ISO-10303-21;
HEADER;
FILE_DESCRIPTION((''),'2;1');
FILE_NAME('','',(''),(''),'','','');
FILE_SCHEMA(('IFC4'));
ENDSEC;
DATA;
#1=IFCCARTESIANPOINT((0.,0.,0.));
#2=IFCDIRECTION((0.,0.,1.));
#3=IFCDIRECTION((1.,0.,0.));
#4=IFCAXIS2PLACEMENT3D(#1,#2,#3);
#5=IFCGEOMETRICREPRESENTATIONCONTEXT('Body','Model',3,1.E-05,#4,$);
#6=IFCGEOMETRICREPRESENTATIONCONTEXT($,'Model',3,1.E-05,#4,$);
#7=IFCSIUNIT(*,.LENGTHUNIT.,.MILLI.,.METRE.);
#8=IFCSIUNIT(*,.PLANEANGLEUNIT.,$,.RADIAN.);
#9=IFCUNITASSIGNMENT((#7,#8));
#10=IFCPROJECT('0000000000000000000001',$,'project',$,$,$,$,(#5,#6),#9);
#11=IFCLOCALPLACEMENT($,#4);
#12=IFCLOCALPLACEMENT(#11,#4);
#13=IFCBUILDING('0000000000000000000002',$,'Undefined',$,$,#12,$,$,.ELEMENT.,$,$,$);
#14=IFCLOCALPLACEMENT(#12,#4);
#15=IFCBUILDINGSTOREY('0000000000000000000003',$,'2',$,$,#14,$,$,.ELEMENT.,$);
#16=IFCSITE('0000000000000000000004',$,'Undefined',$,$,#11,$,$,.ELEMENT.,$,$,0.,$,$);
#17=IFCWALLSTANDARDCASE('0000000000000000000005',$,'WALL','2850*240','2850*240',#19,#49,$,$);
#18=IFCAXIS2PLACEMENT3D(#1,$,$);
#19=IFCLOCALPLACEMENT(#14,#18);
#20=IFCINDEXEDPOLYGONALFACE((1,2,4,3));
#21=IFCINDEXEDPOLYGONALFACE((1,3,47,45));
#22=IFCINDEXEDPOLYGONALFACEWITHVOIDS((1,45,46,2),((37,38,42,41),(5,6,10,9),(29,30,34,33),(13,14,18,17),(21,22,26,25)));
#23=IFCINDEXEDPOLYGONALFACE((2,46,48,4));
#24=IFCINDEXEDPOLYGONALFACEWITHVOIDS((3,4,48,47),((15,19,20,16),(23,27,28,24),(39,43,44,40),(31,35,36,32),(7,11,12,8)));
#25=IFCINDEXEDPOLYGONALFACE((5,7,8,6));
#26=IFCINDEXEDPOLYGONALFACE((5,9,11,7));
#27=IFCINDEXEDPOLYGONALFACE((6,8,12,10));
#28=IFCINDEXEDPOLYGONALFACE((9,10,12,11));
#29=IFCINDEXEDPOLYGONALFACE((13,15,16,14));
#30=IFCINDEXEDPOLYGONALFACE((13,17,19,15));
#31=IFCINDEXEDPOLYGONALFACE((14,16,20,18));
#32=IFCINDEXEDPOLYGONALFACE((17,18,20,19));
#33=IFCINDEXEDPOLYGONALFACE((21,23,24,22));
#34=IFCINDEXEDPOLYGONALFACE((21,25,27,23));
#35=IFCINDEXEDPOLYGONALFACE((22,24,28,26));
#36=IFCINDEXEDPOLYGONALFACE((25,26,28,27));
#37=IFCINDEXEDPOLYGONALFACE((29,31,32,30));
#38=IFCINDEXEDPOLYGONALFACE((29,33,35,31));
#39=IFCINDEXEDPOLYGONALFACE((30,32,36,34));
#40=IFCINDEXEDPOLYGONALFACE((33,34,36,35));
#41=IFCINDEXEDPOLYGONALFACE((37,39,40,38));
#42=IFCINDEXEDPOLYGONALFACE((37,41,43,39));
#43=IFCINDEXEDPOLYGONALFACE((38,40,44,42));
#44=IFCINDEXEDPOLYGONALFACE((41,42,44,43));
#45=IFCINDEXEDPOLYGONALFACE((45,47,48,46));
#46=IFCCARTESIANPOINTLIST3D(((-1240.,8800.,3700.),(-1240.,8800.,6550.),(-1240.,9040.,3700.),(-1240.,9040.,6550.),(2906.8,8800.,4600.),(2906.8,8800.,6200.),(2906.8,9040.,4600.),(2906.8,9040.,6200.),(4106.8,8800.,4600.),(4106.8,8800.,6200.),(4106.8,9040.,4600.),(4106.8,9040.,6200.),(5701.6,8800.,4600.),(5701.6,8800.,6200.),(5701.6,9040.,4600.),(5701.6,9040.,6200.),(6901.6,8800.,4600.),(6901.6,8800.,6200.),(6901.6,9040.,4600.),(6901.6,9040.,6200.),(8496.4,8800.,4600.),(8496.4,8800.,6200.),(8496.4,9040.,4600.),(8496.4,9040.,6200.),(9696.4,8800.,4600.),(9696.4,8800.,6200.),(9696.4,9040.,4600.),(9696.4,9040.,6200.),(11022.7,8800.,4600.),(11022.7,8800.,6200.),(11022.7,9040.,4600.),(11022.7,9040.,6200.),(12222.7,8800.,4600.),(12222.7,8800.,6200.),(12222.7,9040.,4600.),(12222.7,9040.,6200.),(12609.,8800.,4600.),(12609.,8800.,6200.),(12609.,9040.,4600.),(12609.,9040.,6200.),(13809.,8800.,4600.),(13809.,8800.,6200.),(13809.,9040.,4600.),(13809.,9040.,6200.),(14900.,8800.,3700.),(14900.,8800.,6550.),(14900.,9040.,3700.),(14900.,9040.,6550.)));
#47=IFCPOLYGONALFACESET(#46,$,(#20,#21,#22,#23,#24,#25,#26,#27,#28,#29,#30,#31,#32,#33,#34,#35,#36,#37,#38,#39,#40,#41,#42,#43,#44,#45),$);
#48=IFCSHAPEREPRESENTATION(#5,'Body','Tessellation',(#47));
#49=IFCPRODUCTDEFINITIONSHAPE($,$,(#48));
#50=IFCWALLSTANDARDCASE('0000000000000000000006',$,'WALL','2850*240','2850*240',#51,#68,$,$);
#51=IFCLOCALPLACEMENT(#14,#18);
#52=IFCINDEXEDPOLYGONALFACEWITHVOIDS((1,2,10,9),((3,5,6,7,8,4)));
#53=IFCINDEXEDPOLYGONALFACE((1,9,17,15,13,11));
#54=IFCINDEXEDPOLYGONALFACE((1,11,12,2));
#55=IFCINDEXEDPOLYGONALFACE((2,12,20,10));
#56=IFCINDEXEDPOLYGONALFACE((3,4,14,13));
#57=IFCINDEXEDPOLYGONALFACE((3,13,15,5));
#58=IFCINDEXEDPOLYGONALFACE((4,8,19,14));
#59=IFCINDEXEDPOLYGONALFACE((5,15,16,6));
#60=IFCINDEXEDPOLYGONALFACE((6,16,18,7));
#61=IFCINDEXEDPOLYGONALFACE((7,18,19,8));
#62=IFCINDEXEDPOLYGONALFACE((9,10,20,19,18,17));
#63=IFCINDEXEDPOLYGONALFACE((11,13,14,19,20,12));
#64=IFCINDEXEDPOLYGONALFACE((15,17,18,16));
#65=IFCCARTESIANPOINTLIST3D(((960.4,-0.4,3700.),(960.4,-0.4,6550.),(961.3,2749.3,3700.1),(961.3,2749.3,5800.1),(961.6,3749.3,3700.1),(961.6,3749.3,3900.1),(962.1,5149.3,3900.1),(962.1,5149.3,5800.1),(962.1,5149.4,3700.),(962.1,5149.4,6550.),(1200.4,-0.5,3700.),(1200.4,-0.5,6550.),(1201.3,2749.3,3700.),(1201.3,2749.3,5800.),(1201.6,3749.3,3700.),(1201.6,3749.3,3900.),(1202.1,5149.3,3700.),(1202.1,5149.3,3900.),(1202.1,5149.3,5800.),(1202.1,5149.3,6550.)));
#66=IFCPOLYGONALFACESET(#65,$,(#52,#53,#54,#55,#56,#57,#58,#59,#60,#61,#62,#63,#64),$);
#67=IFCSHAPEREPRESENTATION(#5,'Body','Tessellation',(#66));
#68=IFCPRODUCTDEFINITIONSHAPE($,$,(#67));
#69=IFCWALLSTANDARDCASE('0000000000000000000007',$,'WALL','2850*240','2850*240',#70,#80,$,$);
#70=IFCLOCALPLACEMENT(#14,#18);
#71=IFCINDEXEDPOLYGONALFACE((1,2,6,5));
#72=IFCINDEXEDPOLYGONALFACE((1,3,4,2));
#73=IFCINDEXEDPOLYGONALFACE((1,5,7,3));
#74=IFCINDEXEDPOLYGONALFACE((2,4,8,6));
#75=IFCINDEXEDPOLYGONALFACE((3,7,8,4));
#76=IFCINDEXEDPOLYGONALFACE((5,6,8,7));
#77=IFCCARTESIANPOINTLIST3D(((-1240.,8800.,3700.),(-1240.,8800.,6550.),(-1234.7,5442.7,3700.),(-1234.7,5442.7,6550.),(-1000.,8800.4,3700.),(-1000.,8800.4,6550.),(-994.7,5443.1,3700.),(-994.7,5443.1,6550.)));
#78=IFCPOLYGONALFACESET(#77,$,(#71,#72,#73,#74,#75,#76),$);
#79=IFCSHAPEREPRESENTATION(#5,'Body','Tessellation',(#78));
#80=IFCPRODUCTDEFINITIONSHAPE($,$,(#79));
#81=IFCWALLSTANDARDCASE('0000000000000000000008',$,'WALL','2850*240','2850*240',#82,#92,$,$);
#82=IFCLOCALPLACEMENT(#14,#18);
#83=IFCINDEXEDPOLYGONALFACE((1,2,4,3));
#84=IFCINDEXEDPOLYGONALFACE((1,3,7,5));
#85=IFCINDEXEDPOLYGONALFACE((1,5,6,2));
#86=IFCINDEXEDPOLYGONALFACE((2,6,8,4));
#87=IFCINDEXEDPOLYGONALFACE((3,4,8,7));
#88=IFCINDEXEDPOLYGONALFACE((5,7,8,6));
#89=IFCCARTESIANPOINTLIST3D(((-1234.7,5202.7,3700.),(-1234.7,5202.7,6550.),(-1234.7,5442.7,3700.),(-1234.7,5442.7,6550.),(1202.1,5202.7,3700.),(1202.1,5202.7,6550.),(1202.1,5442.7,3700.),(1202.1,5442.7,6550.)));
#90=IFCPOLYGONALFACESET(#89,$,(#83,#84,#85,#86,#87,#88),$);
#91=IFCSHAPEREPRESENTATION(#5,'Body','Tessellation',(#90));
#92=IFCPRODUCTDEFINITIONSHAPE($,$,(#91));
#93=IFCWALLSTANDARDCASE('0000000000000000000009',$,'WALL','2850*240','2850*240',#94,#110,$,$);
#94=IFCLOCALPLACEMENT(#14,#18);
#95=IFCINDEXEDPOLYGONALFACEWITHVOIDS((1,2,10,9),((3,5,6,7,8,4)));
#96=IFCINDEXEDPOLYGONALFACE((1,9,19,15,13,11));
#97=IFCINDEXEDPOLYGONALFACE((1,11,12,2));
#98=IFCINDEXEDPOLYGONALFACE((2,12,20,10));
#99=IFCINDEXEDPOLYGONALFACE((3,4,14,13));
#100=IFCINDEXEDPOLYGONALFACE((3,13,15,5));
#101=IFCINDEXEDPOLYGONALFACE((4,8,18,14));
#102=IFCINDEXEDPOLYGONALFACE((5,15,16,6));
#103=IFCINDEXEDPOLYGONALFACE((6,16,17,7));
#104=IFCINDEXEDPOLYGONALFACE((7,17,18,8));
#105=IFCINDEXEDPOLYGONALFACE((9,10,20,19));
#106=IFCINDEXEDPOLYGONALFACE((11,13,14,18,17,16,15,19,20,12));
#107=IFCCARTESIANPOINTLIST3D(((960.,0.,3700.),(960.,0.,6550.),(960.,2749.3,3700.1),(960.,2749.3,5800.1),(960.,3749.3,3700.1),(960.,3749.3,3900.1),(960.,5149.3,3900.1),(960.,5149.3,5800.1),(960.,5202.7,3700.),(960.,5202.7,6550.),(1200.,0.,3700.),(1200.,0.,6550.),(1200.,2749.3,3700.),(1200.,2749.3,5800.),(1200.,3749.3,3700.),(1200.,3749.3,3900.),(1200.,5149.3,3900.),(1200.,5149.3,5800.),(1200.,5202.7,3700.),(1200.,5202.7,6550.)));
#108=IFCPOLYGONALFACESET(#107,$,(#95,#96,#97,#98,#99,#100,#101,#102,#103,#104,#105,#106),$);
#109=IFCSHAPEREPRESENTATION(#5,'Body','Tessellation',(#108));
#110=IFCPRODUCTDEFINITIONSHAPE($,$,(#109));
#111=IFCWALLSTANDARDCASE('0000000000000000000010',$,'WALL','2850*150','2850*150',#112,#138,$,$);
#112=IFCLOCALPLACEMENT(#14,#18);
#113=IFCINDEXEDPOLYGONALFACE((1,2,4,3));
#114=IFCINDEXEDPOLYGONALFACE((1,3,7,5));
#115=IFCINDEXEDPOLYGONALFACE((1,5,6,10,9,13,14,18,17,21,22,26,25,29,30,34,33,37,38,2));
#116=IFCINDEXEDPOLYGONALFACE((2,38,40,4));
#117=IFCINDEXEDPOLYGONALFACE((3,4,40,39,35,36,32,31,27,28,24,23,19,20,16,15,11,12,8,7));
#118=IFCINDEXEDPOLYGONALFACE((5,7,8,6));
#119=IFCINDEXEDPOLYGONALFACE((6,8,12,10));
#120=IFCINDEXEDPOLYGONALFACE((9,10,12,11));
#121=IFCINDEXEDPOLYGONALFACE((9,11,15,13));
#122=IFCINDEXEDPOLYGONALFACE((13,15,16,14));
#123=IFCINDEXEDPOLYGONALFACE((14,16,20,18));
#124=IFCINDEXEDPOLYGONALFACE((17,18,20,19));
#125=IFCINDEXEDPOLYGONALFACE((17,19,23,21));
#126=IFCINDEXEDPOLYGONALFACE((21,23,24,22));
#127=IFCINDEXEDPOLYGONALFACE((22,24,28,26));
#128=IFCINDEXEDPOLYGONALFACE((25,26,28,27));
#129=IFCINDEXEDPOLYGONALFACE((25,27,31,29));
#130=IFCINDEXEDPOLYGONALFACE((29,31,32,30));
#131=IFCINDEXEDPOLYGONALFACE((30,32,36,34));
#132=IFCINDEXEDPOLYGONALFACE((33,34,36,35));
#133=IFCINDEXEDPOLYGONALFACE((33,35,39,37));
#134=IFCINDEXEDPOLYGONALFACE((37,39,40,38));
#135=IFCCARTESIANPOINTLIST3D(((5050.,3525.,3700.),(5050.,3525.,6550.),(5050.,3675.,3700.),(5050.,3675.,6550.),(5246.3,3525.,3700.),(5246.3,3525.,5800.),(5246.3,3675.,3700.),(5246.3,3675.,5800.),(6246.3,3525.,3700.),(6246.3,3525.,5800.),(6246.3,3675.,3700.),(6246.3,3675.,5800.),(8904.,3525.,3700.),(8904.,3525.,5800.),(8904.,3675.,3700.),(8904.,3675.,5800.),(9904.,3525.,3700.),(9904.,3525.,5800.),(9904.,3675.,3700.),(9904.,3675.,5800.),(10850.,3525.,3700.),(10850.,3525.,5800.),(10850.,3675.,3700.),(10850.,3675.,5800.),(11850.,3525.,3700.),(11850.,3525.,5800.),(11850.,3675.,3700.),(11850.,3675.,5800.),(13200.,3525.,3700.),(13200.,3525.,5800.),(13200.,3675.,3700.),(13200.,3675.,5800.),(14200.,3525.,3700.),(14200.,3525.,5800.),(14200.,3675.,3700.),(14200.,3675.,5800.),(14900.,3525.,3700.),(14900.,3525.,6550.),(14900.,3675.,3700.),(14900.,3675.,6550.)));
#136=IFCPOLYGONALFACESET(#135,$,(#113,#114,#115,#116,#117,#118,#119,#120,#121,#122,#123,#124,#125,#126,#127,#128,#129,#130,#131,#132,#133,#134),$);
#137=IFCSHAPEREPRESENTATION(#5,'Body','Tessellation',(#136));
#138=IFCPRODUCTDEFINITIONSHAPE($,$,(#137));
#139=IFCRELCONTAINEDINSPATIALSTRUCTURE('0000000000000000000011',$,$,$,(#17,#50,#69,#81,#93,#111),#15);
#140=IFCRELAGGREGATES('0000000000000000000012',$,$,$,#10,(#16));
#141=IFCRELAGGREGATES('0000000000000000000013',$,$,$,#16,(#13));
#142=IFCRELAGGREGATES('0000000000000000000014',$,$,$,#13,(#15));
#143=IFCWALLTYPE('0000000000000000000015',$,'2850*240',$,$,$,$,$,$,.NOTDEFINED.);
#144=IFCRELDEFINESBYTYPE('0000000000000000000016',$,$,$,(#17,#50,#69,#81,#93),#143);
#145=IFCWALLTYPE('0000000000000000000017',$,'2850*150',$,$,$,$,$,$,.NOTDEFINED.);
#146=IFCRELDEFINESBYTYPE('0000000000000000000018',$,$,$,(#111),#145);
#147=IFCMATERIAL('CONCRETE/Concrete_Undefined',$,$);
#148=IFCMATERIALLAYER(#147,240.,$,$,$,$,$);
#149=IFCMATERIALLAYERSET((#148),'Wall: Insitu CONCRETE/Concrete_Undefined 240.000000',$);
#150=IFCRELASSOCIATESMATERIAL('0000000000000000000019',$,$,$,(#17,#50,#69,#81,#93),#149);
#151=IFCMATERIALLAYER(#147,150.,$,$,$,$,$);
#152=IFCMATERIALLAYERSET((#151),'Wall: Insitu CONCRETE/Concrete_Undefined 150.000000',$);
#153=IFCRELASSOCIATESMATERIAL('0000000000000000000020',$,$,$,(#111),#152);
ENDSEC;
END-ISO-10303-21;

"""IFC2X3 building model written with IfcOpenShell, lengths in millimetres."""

from ifc_helpers import new_model, si_unit, frame, frame_2d, origin_with_axes, place, context, project, spatial, polyline, rectangle, outline, extrude, material, layer, layer_set, layer_usage, type_object, element, save


model = new_model("IFC2X3")

# Units and contexts
model_context_1 = context("Model", 3, precision=1e-05, world=origin_with_axes(), identifier="Body")
model_context_2 = context("Model", 3, precision=1e-05, world=origin_with_axes())
ifc_project = project(units=[si_unit("LENGTHUNIT", "METRE", prefix="MILLI"), si_unit("PLANEANGLEUNIT", "RADIAN")], contexts=[model_context_1, model_context_2])

# Site, building, storey
site_placement = place(None, origin_with_axes())
site = spatial("IfcSite", under=ifc_project, at=site_placement, Name="Undefined", CompositionType="ELEMENT", RefElevation=0.0)
building_placement = place(site_placement, origin_with_axes())
building = spatial("IfcBuilding", under=site, at=building_placement, Name="Undefined", CompositionType="ELEMENT")
storey_placement = place(building_placement, origin_with_axes())
storey = spatial("IfcBuildingStorey", under=building, at=storey_placement, Name="2", CompositionType="ELEMENT")

# Shared definitions
ifc_material = material(Name="CONCRETE/Concrete_Undefined")

# Wall, openings
ifc_layer_1 = layer(ifc_material, 240.0)
ifc_layer_set_1 = layer_set([ifc_layer_1], Name="Wall: Insitu CONCRETE/Concrete_Undefined 240.000000")
ifc_layer_usage_1 = layer_usage(ifc_layer_set_1, "AXIS2", "POSITIVE", -120.0)
wall_type_1 = type_object("IfcWallType", Name="2850*240", PredefinedType="NOTDEFINED")
wall_1_placement = place(storey_placement, frame((14900.0, 8920.0, 3700.0), z_axis=(0.0, 0.0, 1.0), x_axis=(-1.0, 0.0, 0.0)))
wall_1 = element("IfcWallStandardCase", 1, at=wall_1_placement, inside=storey, type_object=wall_type_1, material=ifc_layer_usage_1, Name="WALL", Description="2850*240", ObjectType="2850*240", context=model_context_1, shape_type="SweptSolid", body=[
    extrude(rectangle(XDim=16140.0, YDim=240.0, at=frame_2d((0.0, 8070.0), x_axis=(0.0, -1.0))), frame((0.0, 0.0, 0.0), z_axis=(0.0, 0.0, 1.0), x_axis=(0.0, -1.0, 0.0)), (0.0, 0.0, 1.0), 2850.0),
])
opening_1_placement = place(storey_placement, frame((14900.0, 8920.0, 3700.0), z_axis=(0.0, 0.0, 1.0), x_axis=(-1.0, 0.0, 0.0)))
element("IfcOpeningElement", 2, at=opening_1_placement, cuts=wall_1, ObjectType="Recess", context=model_context_1, shape_type="SweptSolid", body=[
    extrude(outline(polyline([(0.0, 0.0), (1200.0, 0.0), (1200.0, 1600.0), (0.0, 1600.0), (0.0, 0.0)])), frame((1091.0, -122.5, 2500.0), z_axis=(0.0, 1.0, 0.0), x_axis=(1.0, 0.0, 0.0)), (0.0, 0.0, 1.0), 245.0),
])
opening_2_placement = place(storey_placement, frame((14900.0, 8920.0, 3700.0), z_axis=(0.0, 0.0, 1.0), x_axis=(-1.0, 0.0, 0.0)))
element("IfcOpeningElement", 3, at=opening_2_placement, cuts=wall_1, ObjectType="Recess", context=model_context_1, shape_type="SweptSolid", body=[
    extrude(outline(polyline([(0.0, 0.0), (1200.0, 0.0), (1200.0, 1600.0), (0.0, 1600.0), (0.0, 0.0)])), frame((2677.3, -122.5, 2500.0), z_axis=(0.0, 1.0, 0.0), x_axis=(1.0, 0.0, 0.0)), (0.0, 0.0, 1.0), 245.0),
])
opening_3_placement = place(storey_placement, frame((14900.0, 8920.0, 3700.0), z_axis=(0.0, 0.0, 1.0), x_axis=(-1.0, 0.0, 0.0)))
element("IfcOpeningElement", 4, at=opening_3_placement, cuts=wall_1, ObjectType="Recess", context=model_context_1, shape_type="SweptSolid", body=[
    extrude(outline(polyline([(0.0, 0.0), (1200.0, 0.0), (1200.0, 1600.0), (0.0, 1600.0), (0.0, 0.0)])), frame((5203.6, -122.5, 2500.0), z_axis=(0.0, 1.0, 0.0), x_axis=(1.0, 0.0, 0.0)), (0.0, 0.0, 1.0), 245.0),
])
opening_4_placement = place(storey_placement, frame((14900.0, 8920.0, 3700.0), z_axis=(0.0, 0.0, 1.0), x_axis=(-1.0, 0.0, 0.0)))
element("IfcOpeningElement", 5, at=opening_4_placement, cuts=wall_1, ObjectType="Recess", context=model_context_1, shape_type="SweptSolid", body=[
    extrude(outline(polyline([(0.0, 0.0), (1200.0, 0.0), (1200.0, 1600.0), (0.0, 1600.0), (0.0, 0.0)])), frame((7998.4, -122.5, 2500.0), z_axis=(0.0, 1.0, 0.0), x_axis=(1.0, 0.0, 0.0)), (0.0, 0.0, 1.0), 245.0),
])
opening_5_placement = place(storey_placement, frame((14900.0, 8920.0, 3700.0), z_axis=(0.0, 0.0, 1.0), x_axis=(-1.0, 0.0, 0.0)))
element("IfcOpeningElement", 6, at=opening_5_placement, cuts=wall_1, ObjectType="Recess", context=model_context_1, shape_type="SweptSolid", body=[
    extrude(outline(polyline([(0.0, 0.0), (1200.0, 0.0), (1200.0, 1600.0), (0.0, 1600.0), (0.0, 0.0)])), frame((10793.2, -122.5, 2500.0), z_axis=(0.0, 1.0, 0.0), x_axis=(1.0, 0.0, 0.0)), (0.0, 0.0, 1.0), 245.0),
])

# Wall, opening
ifc_layer_usage_2 = layer_usage(ifc_layer_set_1, "AXIS2", "POSITIVE", -120.0)
wall_2_placement = place(storey_placement, frame((1082.1, 5149.4, 3700.0), z_axis=(0.0, 0.0, 1.0), x_axis=(-0.000319, -1.0, 0.0)))
wall_2 = element("IfcWallStandardCase", 7, at=wall_2_placement, inside=storey, type_object=wall_type_1, material=ifc_layer_usage_2, Name="WALL", Description="2850*240", ObjectType="2850*240", context=model_context_1, shape_type="SweptSolid", body=[
    extrude(rectangle(XDim=5149.8, YDim=240.0, at=frame_2d((0.0, 2574.9), x_axis=(0.0, -1.0))), frame((0.0, 0.0, 0.0), z_axis=(0.0, 0.0, 1.0), x_axis=(0.0, -1.0, 0.0)), (0.0, 0.0, 1.0), 2850.0),
])
opening_6_placement = place(storey_placement, frame((1082.1, 5149.4, 3700.0), z_axis=(0.0, 0.0, 1.0), x_axis=(-0.000319, -1.0, 0.0)))
element("IfcOpeningElement", 8, at=opening_6_placement, cuts=wall_2, ObjectType="Recess", context=model_context_1, shape_type="SweptSolid", body=[
    extrude(outline(polyline([(0.0, 0.0), (2400.0, 0.0), (2400.0, 1900.0), (1000.0, 1900.0), (1000.0, 2100.0), (0.0, 2100.0), (0.0, 0.0)])), frame((2400.0, 124.1, 2100.0), z_axis=(0.000319, -1.0, 0.000213), x_axis=(-1.0, -0.000319, 0.0)), (0.0, 0.0, 1.0), 248.0),
])

# Walls
ifc_layer_usage_3 = layer_usage(ifc_layer_set_1, "AXIS2", "POSITIVE", -120.0)
wall_3_placement = place(storey_placement, frame((-1120.0, 8800.2, 3700.0), z_axis=(0.0, 0.0, 1.0), x_axis=(0.001564, -0.999999, 0.0)))
element("IfcWallStandardCase", 9, at=wall_3_placement, inside=storey, type_object=wall_type_1, material=ifc_layer_usage_3, Name="WALL", Description="2850*240", ObjectType="2850*240", context=model_context_1, shape_type="SweptSolid", body=[
    extrude(rectangle(XDim=3357.3, YDim=240.0, at=frame_2d((0.0, 1678.6), x_axis=(0.0, -1.0))), frame((0.0, 0.0, 0.0), z_axis=(0.0, 0.0, 1.0), x_axis=(0.0, -1.0, 0.0)), (0.0, 0.0, 1.0), 2850.0),
])
ifc_layer_usage_4 = layer_usage(ifc_layer_set_1, "AXIS2", "POSITIVE", -120.0)
wall_4_placement = place(storey_placement, frame((-1234.7, 5322.7, 3700.0), z_axis=(0.0, 0.0, 1.0), x_axis=(1.0, 0.0, 0.0)))
element("IfcWallStandardCase", 10, at=wall_4_placement, inside=storey, type_object=wall_type_1, material=ifc_layer_usage_4, Name="WALL", Description="2850*240", ObjectType="2850*240", context=model_context_1, shape_type="SweptSolid", body=[
    extrude(rectangle(XDim=2436.8, YDim=240.0, at=frame_2d((0.0, 1218.4), x_axis=(0.0, -1.0))), frame((0.0, 0.0, 0.0), z_axis=(0.0, 0.0, 1.0), x_axis=(0.0, -1.0, 0.0)), (0.0, 0.0, 1.0), 2850.0),
])

# Wall, opening
ifc_layer_usage_5 = layer_usage(ifc_layer_set_1, "AXIS2", "POSITIVE", -120.0)
wall_5_placement = place(storey_placement, frame((1080.0, 0.0, 3700.0), z_axis=(0.0, 0.0, 1.0), x_axis=(0.0, 1.0, 0.0)))
wall_5 = element("IfcWallStandardCase", 11, at=wall_5_placement, inside=storey, type_object=wall_type_1, material=ifc_layer_usage_5, Name="WALL", Description="2850*240", ObjectType="2850*240", context=model_context_1, shape_type="SweptSolid", body=[
    extrude(rectangle(XDim=5202.7, YDim=240.0, at=frame_2d((0.0, 2601.4), x_axis=(0.0, -1.0))), frame((0.0, 0.0, 0.0), z_axis=(0.0, 0.0, 1.0), x_axis=(0.0, -1.0, 0.0)), (0.0, 0.0, 1.0), 2850.0),
])
opening_7_placement = place(storey_placement, frame((1080.0, 0.0, 3700.0), z_axis=(0.0, 0.0, 1.0), x_axis=(0.0, 1.0, 0.0)))
element("IfcOpeningElement", 12, at=opening_7_placement, cuts=wall_5, ObjectType="Recess", context=model_context_1, shape_type="SweptSolid", body=[
    extrude(outline(polyline([(0.0, 0.0), (2400.0, 0.0), (2400.0, 1900.0), (1000.0, 1900.0), (1000.0, 2100.0), (0.0, 2100.0), (0.0, 0.0)])), frame((2749.3, -123.1, 2100.0), z_axis=(0.0, 1.0, 0.000213), x_axis=(1.0, 0.0, 0.0)), (0.0, 0.0, 1.0), 246.0),
])

# Wall, openings
ifc_layer_2 = layer(ifc_material, 150.0)
ifc_layer_set_2 = layer_set([ifc_layer_2], Name="Wall: Insitu CONCRETE/Concrete_Undefined 150.000000")
ifc_layer_usage_6 = layer_usage(ifc_layer_set_2, "AXIS2", "POSITIVE", -75.0)
wall_type_2 = type_object("IfcWallType", Name="2850*150", PredefinedType="NOTDEFINED")
wall_6_placement = place(storey_placement, frame((14900.0, 3600.0, 3700.0), z_axis=(0.0, 0.0, 1.0), x_axis=(-1.0, 0.0, 0.0)))
wall_6 = element("IfcWallStandardCase", 13, at=wall_6_placement, inside=storey, type_object=wall_type_2, material=ifc_layer_usage_6, Name="WALL", Description="2850*150", ObjectType="2850*150", context=model_context_1, shape_type="SweptSolid", body=[
    extrude(rectangle(XDim=9850.0, YDim=150.0, at=frame_2d((0.0, 4925.0), x_axis=(0.0, -1.0))), frame((0.0, 0.0, 0.0), z_axis=(0.0, 0.0, 1.0), x_axis=(0.0, -1.0, 0.0)), (0.0, 0.0, 1.0), 2850.0),
])
opening_8_placement = place(storey_placement, frame((14900.0, 3600.0, 3700.0), z_axis=(0.0, 0.0, 1.0), x_axis=(-1.0, 0.0, 0.0)))
element("IfcOpeningElement", 14, at=opening_8_placement, cuts=wall_6, ObjectType="Recess", context=model_context_1, shape_type="SweptSolid", body=[
    extrude(outline(polyline([(0.0, 0.0), (1000.0, 0.0), (1000.0, 2100.0), (0.0, 2100.0), (0.0, 0.0)])), frame((8653.7, 78.0, 0.0), z_axis=(0.0, -1.0, 0.0), x_axis=(1.0, 0.0, 0.0)), (0.0, 0.0, 1.0), 156.0),
])
opening_9_placement = place(storey_placement, frame((14900.0, 3600.0, 3700.0), z_axis=(0.0, 0.0, 1.0), x_axis=(-1.0, 0.0, 0.0)))
element("IfcOpeningElement", 15, at=opening_9_placement, cuts=wall_6, ObjectType="Recess", context=model_context_1, shape_type="SweptSolid", body=[
    extrude(outline(polyline([(0.0, 0.0), (1000.0, 0.0), (1000.0, 2100.0), (0.0, 2100.0), (0.0, 0.0)])), frame((5996.0, 78.0, 2100.0), z_axis=(-0.000005, -1.0, -0.000013), x_axis=(-1.0, 0.0, 0.0)), (0.0, 0.0, 1.0), 156.0),
])
opening_10_placement = place(storey_placement, frame((14900.0, 3600.0, 3700.0), z_axis=(0.0, 0.0, 1.0), x_axis=(-1.0, 0.0, 0.0)))
element("IfcOpeningElement", 16, at=opening_10_placement, cuts=wall_6, ObjectType="Recess", context=model_context_1, shape_type="SweptSolid", body=[
    extrude(outline(polyline([(0.0, 0.0), (1000.0, 0.0), (1000.0, 2100.0), (0.0, 2100.0), (0.0, 0.0)])), frame((4050.0, 78.0, 2100.0), z_axis=(-0.000005, -1.0, 0.000005), x_axis=(-1.0, 0.0, 0.0)), (0.0, 0.0, 1.0), 156.0),
])
opening_11_placement = place(storey_placement, frame((14900.0, 3600.0, 3700.0), z_axis=(0.0, 0.0, 1.0), x_axis=(-1.0, 0.0, 0.0)))
element("IfcOpeningElement", 17, at=opening_11_placement, cuts=wall_6, ObjectType="Recess", context=model_context_1, shape_type="SweptSolid", body=[
    extrude(outline(polyline([(0.0, 0.0), (1000.0, 0.0), (1000.0, 2100.0), (0.0, 2100.0), (0.0, 0.0)])), frame((1700.0, 78.0, 2100.0), z_axis=(0.0, -1.0, 0.0), x_axis=(-1.0, 0.0, 0.0)), (0.0, 0.0, 1.0), 156.0),
])

save(model, "model.ifc")
